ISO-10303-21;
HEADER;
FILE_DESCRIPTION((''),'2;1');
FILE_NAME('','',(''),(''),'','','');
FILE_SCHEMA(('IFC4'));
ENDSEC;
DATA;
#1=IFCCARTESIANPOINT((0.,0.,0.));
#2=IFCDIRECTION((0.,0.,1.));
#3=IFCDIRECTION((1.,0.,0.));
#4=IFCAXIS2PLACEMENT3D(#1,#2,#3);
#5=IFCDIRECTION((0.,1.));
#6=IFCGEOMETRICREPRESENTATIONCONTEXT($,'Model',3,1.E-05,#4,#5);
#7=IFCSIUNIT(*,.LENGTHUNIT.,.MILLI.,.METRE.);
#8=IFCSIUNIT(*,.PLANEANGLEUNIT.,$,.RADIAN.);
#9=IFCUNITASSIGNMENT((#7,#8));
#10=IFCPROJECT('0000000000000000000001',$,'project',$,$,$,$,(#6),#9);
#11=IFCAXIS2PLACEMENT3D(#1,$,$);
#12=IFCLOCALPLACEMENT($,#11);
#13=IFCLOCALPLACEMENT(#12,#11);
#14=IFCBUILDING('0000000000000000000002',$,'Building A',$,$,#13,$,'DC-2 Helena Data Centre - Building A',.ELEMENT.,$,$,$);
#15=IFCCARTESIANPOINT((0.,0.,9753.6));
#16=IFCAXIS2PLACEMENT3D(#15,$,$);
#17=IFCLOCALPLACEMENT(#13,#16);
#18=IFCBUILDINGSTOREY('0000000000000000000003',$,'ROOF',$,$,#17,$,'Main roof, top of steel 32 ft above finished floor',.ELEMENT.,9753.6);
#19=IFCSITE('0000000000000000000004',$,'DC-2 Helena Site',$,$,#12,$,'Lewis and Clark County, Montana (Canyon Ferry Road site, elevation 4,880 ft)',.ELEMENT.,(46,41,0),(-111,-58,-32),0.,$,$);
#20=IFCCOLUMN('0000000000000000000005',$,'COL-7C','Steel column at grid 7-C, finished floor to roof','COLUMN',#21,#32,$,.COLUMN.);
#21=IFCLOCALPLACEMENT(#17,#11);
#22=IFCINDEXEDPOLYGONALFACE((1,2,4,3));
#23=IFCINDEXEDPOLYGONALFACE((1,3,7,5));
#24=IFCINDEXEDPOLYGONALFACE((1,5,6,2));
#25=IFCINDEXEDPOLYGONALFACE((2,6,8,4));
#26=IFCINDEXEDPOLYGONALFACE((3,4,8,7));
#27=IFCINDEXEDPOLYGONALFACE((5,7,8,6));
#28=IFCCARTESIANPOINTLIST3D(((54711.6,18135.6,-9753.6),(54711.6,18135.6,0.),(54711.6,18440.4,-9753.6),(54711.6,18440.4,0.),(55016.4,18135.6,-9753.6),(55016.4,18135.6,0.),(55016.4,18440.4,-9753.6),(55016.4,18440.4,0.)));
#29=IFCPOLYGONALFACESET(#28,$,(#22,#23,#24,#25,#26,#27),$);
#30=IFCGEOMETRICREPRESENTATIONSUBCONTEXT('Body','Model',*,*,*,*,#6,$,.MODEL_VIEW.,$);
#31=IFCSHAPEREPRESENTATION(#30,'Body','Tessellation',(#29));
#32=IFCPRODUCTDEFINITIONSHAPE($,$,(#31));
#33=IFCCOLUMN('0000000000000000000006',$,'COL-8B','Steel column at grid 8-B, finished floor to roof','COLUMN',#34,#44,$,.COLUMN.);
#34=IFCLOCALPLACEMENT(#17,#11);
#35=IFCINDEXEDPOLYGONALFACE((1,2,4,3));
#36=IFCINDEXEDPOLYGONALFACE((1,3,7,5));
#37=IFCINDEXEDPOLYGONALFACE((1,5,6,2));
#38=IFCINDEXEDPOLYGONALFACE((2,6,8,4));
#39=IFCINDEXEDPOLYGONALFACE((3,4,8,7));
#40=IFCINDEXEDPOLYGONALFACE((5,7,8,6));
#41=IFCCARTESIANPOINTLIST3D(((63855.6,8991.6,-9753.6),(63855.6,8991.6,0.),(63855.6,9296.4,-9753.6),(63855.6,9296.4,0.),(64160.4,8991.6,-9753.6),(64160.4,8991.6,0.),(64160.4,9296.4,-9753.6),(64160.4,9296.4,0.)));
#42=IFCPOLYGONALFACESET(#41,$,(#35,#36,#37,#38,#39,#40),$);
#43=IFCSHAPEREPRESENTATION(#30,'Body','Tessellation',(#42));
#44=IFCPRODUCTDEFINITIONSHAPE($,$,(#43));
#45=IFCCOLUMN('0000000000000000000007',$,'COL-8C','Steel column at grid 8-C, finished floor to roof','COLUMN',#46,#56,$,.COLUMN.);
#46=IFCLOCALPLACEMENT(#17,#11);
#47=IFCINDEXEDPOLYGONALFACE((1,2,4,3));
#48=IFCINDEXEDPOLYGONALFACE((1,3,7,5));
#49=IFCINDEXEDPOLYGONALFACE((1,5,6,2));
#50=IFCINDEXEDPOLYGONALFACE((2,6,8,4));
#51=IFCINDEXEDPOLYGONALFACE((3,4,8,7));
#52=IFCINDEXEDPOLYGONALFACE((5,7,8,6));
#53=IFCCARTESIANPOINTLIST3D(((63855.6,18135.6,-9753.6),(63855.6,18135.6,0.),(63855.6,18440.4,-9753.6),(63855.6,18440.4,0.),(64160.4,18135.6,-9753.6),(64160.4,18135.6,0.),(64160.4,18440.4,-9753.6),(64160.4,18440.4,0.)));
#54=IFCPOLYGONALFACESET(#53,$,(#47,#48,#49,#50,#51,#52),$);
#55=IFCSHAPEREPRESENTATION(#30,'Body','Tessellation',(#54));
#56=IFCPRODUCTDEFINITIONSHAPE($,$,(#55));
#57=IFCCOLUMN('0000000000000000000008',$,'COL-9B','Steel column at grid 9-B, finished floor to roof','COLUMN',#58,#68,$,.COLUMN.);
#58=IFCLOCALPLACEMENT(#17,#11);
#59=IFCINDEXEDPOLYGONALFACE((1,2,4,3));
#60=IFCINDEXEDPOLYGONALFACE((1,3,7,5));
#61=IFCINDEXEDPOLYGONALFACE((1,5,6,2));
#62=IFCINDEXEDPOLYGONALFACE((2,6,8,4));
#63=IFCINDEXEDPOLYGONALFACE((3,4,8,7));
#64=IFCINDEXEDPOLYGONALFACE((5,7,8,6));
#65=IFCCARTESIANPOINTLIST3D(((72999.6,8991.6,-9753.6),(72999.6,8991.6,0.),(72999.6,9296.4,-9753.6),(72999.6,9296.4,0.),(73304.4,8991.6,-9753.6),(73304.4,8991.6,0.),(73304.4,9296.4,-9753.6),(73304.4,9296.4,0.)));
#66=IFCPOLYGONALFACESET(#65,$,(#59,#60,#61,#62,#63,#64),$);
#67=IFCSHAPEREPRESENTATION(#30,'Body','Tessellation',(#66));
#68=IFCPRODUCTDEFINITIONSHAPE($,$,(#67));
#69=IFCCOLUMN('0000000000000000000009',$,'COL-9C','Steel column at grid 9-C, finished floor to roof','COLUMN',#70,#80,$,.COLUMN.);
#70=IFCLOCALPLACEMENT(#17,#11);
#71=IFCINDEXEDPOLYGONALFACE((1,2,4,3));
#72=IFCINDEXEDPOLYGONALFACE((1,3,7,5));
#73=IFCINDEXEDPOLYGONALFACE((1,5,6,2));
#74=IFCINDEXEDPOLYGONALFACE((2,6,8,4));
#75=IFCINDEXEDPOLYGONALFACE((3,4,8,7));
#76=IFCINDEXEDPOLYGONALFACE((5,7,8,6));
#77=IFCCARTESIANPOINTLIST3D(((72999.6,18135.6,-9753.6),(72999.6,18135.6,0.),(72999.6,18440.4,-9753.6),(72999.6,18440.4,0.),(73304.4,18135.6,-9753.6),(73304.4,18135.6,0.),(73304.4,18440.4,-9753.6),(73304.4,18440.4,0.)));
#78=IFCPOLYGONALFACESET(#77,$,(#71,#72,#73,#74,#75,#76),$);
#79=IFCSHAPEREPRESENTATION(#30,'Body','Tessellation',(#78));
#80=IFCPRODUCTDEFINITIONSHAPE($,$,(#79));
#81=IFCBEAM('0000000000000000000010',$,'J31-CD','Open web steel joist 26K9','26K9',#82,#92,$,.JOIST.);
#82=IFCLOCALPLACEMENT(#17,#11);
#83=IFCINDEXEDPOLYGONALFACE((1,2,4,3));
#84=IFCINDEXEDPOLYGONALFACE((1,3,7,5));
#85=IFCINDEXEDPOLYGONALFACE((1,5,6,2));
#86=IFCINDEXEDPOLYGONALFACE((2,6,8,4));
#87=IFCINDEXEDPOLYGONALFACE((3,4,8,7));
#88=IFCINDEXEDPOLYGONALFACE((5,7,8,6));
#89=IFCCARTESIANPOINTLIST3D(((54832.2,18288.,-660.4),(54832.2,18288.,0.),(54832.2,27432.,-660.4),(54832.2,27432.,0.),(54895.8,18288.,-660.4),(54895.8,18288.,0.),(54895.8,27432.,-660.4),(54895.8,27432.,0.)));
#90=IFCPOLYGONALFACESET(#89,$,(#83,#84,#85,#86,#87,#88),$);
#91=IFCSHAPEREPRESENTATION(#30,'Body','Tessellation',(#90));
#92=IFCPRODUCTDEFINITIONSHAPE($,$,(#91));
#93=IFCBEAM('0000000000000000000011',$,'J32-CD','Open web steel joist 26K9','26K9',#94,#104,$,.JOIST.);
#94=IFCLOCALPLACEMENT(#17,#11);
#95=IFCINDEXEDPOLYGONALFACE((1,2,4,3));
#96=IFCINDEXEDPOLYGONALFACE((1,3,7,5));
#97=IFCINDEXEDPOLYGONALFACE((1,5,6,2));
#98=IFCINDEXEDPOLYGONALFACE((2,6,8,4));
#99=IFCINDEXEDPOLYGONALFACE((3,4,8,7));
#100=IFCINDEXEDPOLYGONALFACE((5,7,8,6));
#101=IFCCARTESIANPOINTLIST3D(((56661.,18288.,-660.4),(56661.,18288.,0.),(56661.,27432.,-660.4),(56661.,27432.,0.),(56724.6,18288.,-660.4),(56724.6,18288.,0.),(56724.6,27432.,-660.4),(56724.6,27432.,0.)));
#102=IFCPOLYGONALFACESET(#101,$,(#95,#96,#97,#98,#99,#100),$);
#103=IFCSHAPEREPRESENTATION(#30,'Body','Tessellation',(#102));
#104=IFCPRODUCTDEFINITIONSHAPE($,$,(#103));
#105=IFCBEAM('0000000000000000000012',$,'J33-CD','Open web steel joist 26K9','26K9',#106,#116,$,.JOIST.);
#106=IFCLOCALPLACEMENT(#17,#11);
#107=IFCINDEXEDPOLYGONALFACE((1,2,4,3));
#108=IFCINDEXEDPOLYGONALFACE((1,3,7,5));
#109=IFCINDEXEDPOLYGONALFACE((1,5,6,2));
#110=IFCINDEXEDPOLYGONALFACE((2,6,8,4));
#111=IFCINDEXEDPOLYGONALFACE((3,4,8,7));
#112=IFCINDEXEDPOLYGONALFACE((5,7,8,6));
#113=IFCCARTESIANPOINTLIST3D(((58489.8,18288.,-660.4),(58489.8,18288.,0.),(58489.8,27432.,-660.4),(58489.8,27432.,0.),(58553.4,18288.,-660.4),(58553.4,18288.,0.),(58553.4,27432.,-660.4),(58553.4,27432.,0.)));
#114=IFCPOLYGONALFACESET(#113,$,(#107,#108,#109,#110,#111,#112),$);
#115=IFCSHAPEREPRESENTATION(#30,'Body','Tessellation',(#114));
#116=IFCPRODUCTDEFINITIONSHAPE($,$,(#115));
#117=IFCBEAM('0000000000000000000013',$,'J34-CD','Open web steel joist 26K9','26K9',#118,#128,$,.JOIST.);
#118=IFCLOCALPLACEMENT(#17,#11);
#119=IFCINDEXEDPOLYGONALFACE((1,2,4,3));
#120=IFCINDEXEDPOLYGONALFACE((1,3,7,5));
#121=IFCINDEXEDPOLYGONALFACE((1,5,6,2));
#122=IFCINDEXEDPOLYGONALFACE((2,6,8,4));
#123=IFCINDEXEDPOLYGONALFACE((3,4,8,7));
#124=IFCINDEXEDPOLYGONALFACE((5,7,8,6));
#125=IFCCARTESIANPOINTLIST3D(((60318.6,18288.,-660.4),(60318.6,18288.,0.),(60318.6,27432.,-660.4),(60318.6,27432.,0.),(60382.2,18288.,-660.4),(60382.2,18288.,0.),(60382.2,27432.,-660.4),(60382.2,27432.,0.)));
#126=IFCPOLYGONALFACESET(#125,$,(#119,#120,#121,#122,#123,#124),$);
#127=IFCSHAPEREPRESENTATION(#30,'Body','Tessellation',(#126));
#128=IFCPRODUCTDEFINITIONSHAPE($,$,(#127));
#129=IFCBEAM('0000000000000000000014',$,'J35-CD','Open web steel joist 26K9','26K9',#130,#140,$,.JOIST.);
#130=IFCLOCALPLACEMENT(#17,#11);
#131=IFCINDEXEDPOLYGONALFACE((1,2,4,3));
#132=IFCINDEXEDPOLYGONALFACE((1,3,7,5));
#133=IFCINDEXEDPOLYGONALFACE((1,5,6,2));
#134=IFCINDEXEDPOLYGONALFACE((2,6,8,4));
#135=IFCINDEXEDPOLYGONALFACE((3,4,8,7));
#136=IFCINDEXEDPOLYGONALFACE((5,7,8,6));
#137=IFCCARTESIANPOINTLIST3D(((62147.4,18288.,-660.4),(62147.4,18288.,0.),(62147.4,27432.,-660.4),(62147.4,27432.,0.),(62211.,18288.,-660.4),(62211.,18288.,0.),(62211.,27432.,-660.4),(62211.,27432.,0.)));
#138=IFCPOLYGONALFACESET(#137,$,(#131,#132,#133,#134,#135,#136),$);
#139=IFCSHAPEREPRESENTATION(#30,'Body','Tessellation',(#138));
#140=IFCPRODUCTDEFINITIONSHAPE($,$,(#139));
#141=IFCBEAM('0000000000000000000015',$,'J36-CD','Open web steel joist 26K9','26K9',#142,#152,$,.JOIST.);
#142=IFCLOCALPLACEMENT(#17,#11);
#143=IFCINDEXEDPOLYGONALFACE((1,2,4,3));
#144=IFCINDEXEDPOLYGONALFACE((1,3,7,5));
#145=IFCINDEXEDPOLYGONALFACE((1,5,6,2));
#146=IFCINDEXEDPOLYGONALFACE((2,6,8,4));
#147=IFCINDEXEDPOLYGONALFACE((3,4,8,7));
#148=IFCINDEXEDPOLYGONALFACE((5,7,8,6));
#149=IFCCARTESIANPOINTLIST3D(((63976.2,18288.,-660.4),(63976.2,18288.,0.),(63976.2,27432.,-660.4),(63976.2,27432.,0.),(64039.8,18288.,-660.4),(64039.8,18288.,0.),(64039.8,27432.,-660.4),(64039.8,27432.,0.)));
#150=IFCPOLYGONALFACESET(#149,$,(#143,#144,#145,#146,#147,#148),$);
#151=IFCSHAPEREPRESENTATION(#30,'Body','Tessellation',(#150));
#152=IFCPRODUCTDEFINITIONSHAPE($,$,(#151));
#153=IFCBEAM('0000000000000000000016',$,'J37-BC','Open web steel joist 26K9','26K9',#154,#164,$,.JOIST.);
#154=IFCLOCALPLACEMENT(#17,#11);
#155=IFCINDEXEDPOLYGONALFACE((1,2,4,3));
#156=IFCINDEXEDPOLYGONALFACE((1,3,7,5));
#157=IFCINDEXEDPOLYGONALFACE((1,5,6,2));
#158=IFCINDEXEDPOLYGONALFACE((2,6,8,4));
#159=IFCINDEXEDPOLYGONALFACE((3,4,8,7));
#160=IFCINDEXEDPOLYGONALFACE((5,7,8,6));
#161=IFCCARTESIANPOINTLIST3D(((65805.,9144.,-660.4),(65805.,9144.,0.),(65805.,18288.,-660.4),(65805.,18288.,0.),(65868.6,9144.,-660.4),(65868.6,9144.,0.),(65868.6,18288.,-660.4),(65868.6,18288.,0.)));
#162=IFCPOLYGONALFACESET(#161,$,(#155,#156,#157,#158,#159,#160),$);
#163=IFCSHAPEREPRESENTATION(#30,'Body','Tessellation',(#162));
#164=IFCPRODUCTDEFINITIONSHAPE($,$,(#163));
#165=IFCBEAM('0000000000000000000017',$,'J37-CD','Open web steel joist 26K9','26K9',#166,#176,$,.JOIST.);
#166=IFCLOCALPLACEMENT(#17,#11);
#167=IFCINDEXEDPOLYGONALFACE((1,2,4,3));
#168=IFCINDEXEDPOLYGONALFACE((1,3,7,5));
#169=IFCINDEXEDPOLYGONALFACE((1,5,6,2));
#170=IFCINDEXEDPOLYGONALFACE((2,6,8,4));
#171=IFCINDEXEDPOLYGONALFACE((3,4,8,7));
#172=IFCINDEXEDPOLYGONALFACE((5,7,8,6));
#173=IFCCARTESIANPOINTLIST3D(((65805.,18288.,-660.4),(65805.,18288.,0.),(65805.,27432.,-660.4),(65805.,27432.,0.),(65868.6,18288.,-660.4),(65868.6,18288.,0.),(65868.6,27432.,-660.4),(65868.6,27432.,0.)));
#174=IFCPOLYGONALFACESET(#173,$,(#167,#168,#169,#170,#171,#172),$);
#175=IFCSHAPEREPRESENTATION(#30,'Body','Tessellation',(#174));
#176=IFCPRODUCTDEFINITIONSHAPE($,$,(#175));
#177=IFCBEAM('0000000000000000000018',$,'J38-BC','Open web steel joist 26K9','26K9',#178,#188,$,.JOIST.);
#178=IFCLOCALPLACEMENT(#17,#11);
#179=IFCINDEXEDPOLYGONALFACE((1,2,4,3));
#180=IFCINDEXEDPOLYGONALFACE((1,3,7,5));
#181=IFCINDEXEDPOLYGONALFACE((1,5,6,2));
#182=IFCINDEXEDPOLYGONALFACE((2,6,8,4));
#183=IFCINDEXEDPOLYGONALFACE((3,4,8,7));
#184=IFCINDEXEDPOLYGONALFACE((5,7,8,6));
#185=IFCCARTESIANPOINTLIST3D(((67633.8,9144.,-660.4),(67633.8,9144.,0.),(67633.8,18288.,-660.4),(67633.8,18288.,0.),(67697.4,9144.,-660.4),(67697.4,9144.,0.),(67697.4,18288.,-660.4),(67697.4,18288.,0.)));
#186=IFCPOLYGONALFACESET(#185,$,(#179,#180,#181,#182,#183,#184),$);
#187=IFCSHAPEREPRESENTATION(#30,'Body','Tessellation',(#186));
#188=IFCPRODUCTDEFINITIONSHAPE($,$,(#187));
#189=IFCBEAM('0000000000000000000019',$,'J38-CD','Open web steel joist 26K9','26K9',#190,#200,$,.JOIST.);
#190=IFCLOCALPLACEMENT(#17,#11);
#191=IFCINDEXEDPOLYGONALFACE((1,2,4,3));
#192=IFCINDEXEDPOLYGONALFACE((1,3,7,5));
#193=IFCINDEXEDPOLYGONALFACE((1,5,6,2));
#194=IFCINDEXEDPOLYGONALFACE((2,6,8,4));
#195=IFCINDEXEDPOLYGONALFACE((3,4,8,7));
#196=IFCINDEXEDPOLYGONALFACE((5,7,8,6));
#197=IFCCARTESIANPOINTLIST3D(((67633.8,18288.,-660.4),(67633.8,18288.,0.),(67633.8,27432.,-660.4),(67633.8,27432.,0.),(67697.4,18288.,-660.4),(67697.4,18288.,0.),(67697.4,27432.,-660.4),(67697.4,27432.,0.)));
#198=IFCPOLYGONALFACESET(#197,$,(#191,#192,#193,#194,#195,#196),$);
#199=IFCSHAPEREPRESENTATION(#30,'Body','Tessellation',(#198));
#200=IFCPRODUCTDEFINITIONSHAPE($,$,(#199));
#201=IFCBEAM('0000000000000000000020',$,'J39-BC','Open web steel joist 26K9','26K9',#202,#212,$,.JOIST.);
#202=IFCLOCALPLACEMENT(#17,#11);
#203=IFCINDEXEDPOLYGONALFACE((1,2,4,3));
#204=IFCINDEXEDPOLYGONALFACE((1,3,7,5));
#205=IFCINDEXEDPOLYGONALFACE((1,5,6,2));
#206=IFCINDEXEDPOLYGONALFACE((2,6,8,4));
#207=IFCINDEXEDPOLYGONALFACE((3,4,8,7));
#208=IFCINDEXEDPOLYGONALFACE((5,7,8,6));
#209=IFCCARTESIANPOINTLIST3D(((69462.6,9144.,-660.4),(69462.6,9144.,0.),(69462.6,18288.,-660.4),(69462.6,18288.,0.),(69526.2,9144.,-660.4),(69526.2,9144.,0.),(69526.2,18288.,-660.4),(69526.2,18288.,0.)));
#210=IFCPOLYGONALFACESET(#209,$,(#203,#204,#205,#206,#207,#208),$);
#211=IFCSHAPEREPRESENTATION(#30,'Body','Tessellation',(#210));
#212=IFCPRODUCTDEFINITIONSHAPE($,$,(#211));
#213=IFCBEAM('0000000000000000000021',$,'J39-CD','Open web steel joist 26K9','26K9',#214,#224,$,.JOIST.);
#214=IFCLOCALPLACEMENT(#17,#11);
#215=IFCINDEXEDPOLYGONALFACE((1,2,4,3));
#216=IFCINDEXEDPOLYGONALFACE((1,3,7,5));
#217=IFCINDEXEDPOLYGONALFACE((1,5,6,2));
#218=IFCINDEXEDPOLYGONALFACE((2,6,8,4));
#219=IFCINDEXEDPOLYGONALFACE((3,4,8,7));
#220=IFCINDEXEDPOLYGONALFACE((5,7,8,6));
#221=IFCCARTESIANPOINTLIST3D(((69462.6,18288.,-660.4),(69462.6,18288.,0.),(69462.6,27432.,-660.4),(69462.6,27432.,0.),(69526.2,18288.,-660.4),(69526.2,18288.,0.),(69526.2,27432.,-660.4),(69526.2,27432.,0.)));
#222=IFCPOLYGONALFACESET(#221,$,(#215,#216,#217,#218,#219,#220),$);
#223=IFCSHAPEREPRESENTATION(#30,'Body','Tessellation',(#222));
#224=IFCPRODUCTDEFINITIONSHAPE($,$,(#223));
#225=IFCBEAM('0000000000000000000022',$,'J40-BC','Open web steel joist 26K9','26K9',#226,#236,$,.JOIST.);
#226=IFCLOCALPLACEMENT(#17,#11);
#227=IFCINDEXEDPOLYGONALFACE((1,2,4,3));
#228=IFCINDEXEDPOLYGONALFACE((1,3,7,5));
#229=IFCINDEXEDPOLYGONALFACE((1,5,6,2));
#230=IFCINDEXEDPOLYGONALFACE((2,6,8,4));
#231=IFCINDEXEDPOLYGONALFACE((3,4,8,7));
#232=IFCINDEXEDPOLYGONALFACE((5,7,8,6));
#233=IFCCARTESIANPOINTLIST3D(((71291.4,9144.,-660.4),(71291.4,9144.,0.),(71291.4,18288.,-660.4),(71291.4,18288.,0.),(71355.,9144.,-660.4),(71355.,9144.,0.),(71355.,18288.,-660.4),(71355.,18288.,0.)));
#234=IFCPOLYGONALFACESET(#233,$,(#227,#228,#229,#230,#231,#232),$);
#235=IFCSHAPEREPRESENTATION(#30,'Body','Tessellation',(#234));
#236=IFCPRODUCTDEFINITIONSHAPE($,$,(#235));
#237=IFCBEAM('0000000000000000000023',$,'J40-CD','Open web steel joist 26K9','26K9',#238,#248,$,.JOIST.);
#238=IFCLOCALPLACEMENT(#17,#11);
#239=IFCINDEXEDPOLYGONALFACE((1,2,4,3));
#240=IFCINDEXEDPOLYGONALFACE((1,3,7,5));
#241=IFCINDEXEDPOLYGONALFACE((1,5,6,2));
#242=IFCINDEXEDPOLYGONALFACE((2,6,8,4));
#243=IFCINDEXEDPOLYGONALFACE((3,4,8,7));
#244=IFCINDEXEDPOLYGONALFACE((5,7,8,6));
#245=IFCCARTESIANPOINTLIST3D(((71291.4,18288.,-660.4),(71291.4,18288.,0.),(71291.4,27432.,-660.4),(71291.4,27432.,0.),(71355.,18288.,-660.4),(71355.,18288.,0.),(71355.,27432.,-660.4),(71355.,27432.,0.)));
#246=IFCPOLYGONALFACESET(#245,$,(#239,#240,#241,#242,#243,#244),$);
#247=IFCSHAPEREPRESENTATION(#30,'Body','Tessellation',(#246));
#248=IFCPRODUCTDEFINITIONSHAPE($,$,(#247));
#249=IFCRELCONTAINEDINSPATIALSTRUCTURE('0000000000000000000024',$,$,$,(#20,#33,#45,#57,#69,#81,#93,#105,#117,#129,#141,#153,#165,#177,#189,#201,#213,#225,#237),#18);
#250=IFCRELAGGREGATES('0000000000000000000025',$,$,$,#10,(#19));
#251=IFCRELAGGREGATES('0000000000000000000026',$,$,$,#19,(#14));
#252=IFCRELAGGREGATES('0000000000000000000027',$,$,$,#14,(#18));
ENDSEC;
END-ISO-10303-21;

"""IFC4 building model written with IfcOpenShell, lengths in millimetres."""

from ifc_helpers import new_model, si_unit, direction, frame, origin, origin_with_axes, origin_2d, place, context, subcontext, project, spatial, rectangle, extrude, element, save


model = new_model("IFC4")

# Units and contexts
model_context = context("Model", 3, precision=1e-05, world=origin_with_axes(), true_north=direction((0.0, 1.0)))
body_context = subcontext(model_context, "Body", "Model", "MODEL_VIEW")
ifc_project = project(units=[si_unit("LENGTHUNIT", "METRE", prefix="MILLI"), si_unit("PLANEANGLEUNIT", "RADIAN")], contexts=[model_context])

# Site, building, storey
site_placement = place(None, origin())
site = spatial("IfcSite", under=ifc_project, at=site_placement, Name="DC-2 Helena Site", LongName="Lewis and Clark County, Montana (Canyon Ferry Road site, elevation 4,880 ft)", CompositionType="ELEMENT", RefLatitude=(46, 41, 0), RefLongitude=(-111, -58, -32), RefElevation=0.0)
building_placement = place(site_placement, origin())
building = spatial("IfcBuilding", under=site, at=building_placement, Name="Building A", LongName="DC-2 Helena Data Centre - Building A", CompositionType="ELEMENT")
storey_placement = place(building_placement, frame((0.0, 0.0, 9753.6)))
storey = spatial("IfcBuildingStorey", under=building, at=storey_placement, Name="ROOF", LongName="Main roof, top of steel 32 ft above finished floor", CompositionType="ELEMENT", Elevation=9753.6)

# Columns
for number, where, name, description in (
    (1, (54864.0, 18288.0, -9753.6), "COL-7C", "Steel column at grid 7-C, finished floor to roof"),
    (2, (64008.0, 9144.0, -9753.6), "COL-8B", "Steel column at grid 8-B, finished floor to roof"),
    (3, (64008.0, 18288.0, -9753.6), "COL-8C", "Steel column at grid 8-C, finished floor to roof"),
    (4, (73152.0, 9144.0, -9753.6), "COL-9B", "Steel column at grid 9-B, finished floor to roof"),
):
    element("IfcColumn", number, at=place(storey_placement, frame(where)), inside=storey, Name=name, Description=description, ObjectType="COLUMN", PredefinedType="COLUMN", context=body_context, shape_type="SweptSolid", body=[
        extrude(rectangle(XDim=304.8, YDim=304.8, at=origin_2d()), origin(), (0.0, 0.0, 1.0), 9753.6),
    ])
placement_1 = place(storey_placement, frame((73152.0, 18288.0, -9753.6)))
element("IfcColumn", 5, at=placement_1, inside=storey, Name="COL-9C", Description="Steel column at grid 9-C, finished floor to roof", ObjectType="COLUMN", PredefinedType="COLUMN", context=body_context, shape_type="SweptSolid", body=[
    extrude(rectangle(XDim=304.8, YDim=304.8, at=origin_2d()), origin(), (0.0, 0.0, 1.0), 9753.6),
])

# Beams
placement_2 = place(storey_placement, frame((54864.0, 18288.0, 0.0)))
element("IfcBeam", 6, at=placement_2, inside=storey, Name="J31-CD", Description="Open web steel joist 26K9", ObjectType="26K9", PredefinedType="JOIST", context=body_context, shape_type="SweptSolid", body=[
    extrude(rectangle(XDim=63.5, YDim=660.4, at=origin_2d()), frame((0.0, 0.0, -330.2), z_axis=(0.0, 1.0, 0.0), x_axis=(1.0, 0.0, 0.0)), (0.0, 0.0, 1.0), 9144.0),
])
for number, where, name in (
    (7, (56692.8, 18288.0, 0.0), "J32-CD"),
    (8, (58521.6, 18288.0, 0.0), "J33-CD"),
    (9, (60350.4, 18288.0, 0.0), "J34-CD"),
    (10, (62179.2, 18288.0, 0.0), "J35-CD"),
):
    element("IfcBeam", number, at=place(storey_placement, frame(where)), inside=storey, Name=name, Description="Open web steel joist 26K9", ObjectType="26K9", PredefinedType="JOIST", context=body_context, shape_type="SweptSolid", body=[
        extrude(rectangle(XDim=63.5, YDim=660.4, at=origin_2d()), frame((0.0, 0.0, -330.2), z_axis=(0.0, 1.0, 0.0), x_axis=(1.0, 0.0, 0.0)), (0.0, 0.0, 1.0), 9144.0),
    ])
placement_3 = place(storey_placement, frame((64008.0, 18288.0, 0.0)))
element("IfcBeam", 11, at=placement_3, inside=storey, Name="J36-CD", Description="Open web steel joist 26K9", ObjectType="26K9", PredefinedType="JOIST", context=body_context, shape_type="SweptSolid", body=[
    extrude(rectangle(XDim=63.5, YDim=660.4, at=origin_2d()), frame((0.0, 0.0, -330.2), z_axis=(0.0, 1.0, 0.0), x_axis=(1.0, 0.0, 0.0)), (0.0, 0.0, 1.0), 9144.0),
])
for number, where, name in (
    (12, (65836.8, 9144.0, 0.0), "J37-BC"),
    (13, (65836.8, 18288.0, 0.0), "J37-CD"),
    (14, (67665.6, 9144.0, 0.0), "J38-BC"),
    (15, (67665.6, 18288.0, 0.0), "J38-CD"),
    (16, (69494.4, 9144.0, 0.0), "J39-BC"),
    (17, (69494.4, 18288.0, 0.0), "J39-CD"),
    (18, (71323.2, 9144.0, 0.0), "J40-BC"),
    (19, (71323.2, 18288.0, 0.0), "J40-CD"),
):
    element("IfcBeam", number, at=place(storey_placement, frame(where)), inside=storey, Name=name, Description="Open web steel joist 26K9", ObjectType="26K9", PredefinedType="JOIST", context=body_context, shape_type="SweptSolid", body=[
        extrude(rectangle(XDim=63.5, YDim=660.4, at=origin_2d()), frame((0.0, 0.0, -330.2), z_axis=(0.0, 1.0, 0.0), x_axis=(1.0, 0.0, 0.0)), (0.0, 0.0, 1.0), 9144.0),
    ])

save(model, "model.ifc")
